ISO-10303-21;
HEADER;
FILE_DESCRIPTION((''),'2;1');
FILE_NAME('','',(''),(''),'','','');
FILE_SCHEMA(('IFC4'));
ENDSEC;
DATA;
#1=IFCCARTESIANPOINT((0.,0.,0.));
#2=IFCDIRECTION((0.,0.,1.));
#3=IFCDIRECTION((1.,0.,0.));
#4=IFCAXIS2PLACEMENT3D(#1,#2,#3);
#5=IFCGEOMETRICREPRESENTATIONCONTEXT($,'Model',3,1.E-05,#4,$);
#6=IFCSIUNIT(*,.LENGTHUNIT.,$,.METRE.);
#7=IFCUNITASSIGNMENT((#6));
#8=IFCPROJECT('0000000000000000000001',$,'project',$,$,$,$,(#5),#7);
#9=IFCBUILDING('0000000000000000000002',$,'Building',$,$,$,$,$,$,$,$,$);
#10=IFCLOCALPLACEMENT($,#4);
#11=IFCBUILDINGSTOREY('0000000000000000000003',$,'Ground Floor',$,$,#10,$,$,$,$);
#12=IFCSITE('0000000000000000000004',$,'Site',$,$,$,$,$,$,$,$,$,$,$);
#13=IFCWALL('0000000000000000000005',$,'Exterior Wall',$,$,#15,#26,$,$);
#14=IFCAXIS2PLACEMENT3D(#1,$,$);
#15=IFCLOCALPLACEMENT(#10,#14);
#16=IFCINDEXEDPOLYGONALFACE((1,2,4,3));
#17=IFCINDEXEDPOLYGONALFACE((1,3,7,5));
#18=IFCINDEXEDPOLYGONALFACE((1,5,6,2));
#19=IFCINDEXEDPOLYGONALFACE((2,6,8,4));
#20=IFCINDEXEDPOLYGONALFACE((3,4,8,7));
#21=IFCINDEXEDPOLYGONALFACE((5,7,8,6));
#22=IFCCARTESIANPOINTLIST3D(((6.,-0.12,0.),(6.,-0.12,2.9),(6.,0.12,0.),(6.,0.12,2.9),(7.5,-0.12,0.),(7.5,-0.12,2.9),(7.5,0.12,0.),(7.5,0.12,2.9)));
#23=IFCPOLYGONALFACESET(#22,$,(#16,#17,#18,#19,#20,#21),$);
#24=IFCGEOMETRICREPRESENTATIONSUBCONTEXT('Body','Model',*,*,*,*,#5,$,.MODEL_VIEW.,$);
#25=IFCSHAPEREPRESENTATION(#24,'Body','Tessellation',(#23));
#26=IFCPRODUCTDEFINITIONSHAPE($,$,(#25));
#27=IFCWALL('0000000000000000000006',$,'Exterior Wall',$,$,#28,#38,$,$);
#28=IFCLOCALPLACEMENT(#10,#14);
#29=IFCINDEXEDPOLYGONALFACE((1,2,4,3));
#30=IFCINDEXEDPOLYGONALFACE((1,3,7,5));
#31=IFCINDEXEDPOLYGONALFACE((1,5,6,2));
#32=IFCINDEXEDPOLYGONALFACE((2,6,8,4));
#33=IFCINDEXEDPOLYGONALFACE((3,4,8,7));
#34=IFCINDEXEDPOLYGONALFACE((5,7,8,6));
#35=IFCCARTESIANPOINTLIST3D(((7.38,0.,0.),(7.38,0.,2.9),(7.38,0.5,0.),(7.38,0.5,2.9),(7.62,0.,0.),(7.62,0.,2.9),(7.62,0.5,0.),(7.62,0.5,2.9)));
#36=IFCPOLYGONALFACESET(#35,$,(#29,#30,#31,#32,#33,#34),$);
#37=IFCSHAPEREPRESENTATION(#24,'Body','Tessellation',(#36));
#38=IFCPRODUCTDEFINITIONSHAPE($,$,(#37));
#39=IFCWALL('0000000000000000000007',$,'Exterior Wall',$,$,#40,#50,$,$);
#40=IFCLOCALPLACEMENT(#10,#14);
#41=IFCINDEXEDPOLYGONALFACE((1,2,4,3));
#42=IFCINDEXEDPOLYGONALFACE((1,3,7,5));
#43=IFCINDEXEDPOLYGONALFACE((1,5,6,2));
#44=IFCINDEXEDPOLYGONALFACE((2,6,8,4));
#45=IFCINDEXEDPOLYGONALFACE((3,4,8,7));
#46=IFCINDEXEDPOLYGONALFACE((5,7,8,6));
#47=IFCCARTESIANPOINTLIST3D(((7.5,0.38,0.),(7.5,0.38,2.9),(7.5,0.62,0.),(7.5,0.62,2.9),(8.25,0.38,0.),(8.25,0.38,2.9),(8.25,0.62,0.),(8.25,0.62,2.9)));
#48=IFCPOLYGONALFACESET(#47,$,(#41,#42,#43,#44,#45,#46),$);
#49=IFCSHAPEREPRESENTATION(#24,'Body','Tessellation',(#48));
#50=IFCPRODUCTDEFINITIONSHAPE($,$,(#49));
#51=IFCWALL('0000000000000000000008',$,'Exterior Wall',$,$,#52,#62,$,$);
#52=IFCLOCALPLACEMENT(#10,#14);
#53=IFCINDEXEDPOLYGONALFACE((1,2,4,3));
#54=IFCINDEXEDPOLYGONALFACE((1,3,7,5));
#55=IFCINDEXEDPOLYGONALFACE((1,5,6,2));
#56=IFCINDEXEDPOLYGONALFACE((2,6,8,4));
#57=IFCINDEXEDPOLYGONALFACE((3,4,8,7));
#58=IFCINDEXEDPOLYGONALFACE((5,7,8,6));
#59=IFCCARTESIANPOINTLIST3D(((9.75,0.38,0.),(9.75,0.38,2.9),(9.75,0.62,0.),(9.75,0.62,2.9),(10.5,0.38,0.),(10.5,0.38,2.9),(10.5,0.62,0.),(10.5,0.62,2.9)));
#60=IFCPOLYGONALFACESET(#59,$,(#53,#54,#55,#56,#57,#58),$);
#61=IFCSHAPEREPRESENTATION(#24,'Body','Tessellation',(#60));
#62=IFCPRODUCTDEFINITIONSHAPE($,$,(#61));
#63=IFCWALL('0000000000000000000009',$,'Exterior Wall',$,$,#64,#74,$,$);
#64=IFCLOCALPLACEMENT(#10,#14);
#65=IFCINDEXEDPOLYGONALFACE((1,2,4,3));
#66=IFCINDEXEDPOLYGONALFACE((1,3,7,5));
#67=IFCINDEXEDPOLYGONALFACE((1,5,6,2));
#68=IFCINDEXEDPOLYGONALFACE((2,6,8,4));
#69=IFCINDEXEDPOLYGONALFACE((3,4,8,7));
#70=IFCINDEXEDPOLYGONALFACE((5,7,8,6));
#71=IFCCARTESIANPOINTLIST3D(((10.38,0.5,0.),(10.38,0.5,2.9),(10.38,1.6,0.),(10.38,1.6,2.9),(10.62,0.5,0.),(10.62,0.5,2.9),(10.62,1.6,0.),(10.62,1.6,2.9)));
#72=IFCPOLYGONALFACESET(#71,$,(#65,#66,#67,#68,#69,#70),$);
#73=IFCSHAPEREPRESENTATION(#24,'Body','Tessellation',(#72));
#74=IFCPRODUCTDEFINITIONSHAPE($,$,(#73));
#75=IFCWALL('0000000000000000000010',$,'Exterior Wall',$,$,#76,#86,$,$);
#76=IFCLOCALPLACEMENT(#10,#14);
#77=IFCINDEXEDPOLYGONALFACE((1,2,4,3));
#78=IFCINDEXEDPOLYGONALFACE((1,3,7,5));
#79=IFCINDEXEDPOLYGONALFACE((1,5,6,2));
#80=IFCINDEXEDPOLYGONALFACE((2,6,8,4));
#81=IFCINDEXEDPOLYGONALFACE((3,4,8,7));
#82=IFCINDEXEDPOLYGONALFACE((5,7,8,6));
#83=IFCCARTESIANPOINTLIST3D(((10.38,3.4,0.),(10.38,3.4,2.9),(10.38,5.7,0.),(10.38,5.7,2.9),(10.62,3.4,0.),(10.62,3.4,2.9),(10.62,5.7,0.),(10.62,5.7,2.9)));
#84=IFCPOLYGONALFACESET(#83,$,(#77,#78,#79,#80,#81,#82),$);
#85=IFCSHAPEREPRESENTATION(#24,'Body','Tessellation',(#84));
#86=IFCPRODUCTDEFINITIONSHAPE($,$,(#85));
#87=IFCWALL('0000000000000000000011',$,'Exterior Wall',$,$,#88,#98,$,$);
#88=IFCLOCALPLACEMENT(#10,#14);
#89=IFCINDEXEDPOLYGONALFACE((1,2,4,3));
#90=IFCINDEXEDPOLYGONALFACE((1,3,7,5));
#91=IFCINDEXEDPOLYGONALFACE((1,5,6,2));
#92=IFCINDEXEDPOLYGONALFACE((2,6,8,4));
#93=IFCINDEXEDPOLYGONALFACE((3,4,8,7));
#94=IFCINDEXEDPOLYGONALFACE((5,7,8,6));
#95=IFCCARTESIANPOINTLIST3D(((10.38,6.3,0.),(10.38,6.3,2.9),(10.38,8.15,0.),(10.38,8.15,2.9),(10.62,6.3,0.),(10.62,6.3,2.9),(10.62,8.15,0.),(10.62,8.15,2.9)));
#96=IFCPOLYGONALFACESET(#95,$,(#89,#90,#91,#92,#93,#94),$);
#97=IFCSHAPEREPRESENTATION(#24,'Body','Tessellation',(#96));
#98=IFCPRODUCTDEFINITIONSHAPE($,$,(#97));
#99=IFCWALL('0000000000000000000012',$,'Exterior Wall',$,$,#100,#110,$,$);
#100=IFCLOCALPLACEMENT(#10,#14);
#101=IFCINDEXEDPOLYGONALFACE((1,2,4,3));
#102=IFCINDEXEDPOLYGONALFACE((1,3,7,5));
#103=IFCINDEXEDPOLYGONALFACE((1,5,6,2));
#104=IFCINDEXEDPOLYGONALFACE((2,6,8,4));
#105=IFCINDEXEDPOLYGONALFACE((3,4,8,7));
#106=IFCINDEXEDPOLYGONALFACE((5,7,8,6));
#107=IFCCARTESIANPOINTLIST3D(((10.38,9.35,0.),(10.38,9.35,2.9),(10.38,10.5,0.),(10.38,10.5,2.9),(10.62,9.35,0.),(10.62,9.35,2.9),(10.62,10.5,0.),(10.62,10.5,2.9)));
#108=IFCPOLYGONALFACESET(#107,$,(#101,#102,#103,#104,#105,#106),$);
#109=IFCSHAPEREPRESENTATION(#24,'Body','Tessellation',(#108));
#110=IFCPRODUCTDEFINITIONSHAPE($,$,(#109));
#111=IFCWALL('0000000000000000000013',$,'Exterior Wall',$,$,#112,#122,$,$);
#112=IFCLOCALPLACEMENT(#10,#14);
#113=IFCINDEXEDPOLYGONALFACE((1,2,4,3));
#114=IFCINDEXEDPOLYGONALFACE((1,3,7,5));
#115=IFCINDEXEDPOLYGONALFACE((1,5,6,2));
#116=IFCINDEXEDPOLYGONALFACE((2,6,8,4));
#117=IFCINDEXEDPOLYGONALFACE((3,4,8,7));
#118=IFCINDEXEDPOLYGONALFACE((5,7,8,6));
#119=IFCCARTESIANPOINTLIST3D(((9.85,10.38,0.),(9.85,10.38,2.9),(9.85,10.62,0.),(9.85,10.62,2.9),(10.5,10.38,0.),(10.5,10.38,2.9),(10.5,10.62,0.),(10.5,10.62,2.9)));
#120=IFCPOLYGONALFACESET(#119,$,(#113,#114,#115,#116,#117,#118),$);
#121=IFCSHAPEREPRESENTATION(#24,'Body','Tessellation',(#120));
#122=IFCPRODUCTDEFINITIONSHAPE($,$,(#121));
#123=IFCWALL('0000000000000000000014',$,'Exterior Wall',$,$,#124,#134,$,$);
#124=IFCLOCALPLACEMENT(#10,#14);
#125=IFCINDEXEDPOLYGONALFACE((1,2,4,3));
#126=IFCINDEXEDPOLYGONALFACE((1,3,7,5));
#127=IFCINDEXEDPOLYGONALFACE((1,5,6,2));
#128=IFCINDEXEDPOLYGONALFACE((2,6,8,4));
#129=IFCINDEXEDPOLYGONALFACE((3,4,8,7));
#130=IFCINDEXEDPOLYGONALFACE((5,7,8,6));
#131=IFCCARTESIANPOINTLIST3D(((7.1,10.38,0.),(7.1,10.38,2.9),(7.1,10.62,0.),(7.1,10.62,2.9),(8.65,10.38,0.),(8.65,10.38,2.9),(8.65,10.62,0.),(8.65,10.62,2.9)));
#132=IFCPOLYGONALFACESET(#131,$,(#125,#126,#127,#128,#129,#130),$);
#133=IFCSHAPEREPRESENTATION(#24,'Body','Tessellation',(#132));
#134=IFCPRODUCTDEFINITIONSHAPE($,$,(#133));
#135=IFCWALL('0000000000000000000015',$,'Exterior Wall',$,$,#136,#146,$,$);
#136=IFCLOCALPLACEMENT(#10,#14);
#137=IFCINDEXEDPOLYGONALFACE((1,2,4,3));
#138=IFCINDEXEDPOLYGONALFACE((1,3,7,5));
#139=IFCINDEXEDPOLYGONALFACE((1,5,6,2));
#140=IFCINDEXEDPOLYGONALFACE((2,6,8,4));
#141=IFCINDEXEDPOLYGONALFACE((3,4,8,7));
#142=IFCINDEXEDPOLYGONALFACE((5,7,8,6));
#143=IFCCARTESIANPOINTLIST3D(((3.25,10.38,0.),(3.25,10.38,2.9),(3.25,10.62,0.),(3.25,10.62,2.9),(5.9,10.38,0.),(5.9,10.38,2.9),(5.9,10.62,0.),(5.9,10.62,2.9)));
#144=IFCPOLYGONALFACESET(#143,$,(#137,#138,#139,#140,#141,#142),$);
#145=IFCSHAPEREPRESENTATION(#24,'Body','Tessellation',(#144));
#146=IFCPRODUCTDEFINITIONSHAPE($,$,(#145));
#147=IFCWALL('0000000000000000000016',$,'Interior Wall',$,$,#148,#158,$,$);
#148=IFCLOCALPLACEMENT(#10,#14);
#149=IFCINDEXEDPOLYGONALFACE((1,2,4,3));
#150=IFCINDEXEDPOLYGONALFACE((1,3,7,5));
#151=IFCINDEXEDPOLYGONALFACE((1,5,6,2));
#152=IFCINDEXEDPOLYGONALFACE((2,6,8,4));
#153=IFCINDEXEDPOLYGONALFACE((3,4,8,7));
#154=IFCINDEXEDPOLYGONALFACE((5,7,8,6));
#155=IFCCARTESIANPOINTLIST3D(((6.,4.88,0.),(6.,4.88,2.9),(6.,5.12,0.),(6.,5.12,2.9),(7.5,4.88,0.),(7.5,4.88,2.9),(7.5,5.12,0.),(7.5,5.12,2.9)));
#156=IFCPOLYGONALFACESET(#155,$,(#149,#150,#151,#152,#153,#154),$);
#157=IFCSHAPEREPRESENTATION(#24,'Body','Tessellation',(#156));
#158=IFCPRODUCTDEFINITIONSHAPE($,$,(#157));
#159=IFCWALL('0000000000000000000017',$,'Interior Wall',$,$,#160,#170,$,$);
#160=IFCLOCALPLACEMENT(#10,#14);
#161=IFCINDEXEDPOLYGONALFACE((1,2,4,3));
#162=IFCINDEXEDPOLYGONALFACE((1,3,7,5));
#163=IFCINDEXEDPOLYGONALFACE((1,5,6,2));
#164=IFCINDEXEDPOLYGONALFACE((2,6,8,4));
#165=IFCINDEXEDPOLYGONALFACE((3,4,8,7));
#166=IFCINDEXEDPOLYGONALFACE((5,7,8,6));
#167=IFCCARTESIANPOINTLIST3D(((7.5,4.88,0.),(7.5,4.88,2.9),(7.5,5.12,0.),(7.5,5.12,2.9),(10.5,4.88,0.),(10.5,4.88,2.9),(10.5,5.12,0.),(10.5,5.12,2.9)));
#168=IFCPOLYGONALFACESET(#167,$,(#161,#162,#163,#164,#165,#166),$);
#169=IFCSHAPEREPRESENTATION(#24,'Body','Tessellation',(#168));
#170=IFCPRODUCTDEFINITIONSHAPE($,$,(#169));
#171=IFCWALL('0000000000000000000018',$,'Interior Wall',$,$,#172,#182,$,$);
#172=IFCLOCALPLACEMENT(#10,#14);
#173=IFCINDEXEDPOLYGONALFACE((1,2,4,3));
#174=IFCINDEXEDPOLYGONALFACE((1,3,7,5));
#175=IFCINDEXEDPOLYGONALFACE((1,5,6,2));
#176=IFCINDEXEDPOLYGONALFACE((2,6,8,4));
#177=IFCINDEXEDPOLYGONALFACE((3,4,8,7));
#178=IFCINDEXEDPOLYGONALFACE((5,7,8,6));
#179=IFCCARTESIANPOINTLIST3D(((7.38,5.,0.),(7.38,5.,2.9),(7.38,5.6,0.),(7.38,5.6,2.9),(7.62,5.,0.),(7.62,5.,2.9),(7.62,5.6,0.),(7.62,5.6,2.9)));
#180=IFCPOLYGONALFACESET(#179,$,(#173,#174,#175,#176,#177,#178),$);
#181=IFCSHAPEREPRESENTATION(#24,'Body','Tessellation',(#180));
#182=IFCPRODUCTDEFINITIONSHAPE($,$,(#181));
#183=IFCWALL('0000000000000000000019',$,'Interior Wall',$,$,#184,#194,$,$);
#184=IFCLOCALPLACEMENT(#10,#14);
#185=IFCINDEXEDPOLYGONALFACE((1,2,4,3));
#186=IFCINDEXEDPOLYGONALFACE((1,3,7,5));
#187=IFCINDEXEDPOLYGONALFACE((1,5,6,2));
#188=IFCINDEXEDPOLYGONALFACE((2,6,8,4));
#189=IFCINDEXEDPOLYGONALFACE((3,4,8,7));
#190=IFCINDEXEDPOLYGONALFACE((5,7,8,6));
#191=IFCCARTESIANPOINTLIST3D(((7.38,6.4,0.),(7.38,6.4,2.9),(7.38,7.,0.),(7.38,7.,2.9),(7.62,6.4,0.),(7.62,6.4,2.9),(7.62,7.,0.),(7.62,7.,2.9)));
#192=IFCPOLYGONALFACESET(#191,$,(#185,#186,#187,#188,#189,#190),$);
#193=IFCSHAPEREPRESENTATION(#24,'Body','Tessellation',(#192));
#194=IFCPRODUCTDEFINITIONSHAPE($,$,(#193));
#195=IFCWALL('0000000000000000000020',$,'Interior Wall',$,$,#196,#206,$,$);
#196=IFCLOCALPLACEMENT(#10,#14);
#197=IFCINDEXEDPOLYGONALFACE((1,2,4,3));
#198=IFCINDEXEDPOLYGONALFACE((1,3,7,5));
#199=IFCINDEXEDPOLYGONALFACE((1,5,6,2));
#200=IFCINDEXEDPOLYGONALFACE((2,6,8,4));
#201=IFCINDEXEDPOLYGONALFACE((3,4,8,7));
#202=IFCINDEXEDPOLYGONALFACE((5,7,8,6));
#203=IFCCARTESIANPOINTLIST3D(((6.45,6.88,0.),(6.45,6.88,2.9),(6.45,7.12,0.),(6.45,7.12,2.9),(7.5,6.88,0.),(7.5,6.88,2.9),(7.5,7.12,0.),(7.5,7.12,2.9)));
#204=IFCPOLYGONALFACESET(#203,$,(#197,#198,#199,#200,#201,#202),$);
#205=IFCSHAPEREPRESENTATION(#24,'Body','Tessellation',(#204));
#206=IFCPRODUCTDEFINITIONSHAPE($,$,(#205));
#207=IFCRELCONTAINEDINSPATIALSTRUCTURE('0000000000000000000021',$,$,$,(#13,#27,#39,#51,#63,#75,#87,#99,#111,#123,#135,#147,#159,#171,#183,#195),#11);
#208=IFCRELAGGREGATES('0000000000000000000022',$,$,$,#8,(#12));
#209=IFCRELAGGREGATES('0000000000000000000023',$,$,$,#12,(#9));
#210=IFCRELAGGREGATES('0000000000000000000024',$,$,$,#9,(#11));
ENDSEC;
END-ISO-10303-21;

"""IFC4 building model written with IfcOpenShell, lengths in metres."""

from ifc_helpers import new_model, si_unit, frame, origin_with_axes, place, context, subcontext, project, spatial, indexed_curve, outline, extrude, element, save


model = new_model("IFC4")

# Units and contexts
model_context = context("Model", 3, precision=1e-05, world=origin_with_axes())
body_context = subcontext(model_context, "Body", "Model", "MODEL_VIEW")
ifc_project = project(units=[si_unit("LENGTHUNIT", "METRE")], contexts=[model_context])

# Site, building, storey
site = spatial("IfcSite", under=ifc_project, Name="Site")
building = spatial("IfcBuilding", under=site, Name="Building")
storey_placement = place(None, origin_with_axes())
storey = spatial("IfcBuildingStorey", under=building, at=storey_placement, Name="Ground Floor")

# Walls
wall_1_placement = place(storey_placement, frame((6.0, 0.0, 0.0), z_axis=(0.0, 0.0, 1.0), x_axis=(1.0, 0.0, 0.0)))
element("IfcWall", 1, at=wall_1_placement, inside=storey, Name="Exterior Wall", context=body_context, shape_type="SweptSolid", body=[
    extrude(outline(indexed_curve([(0.0, 0.0), (0.0, 0.24), (1.5, 0.24), (1.5, 0.0), (0.0, 0.0)], self_intersect=False)), frame((0.0, -0.12, 0.0), z_axis=(0.0, 0.0, 1.0), x_axis=(1.0, 0.0, 0.0)), (0.0, 0.0, 1.0), 2.9),
])
wall_2_placement = place(storey_placement, frame((7.5, 0.0, 0.0), z_axis=(0.0, 0.0, 1.0), x_axis=(0.0, 1.0, 0.0)))
element("IfcWall", 2, at=wall_2_placement, inside=storey, Name="Exterior Wall", context=body_context, shape_type="SweptSolid", body=[
    extrude(outline(indexed_curve([(0.0, 0.0), (0.0, 0.24), (0.5, 0.24), (0.5, 0.0), (0.0, 0.0)], self_intersect=False)), frame((0.0, -0.12, 0.0), z_axis=(0.0, 0.0, 1.0), x_axis=(1.0, 0.0, 0.0)), (0.0, 0.0, 1.0), 2.9),
])
for number, where, z_axis, x_axis, name in (
    (3, (7.5, 0.5, 0.0), (0.0, 0.0, 1.0), (1.0, 0.0, 0.0), "Exterior Wall"),
    (4, (9.75, 0.5, 0.0), (0.0, 0.0, 1.0), (1.0, 0.0, 0.0), "Exterior Wall"),
):
    element("IfcWall", number, at=place(storey_placement, frame(where, z_axis=z_axis, x_axis=x_axis)), inside=storey, Name=name, context=body_context, shape_type="SweptSolid", body=[
        extrude(outline(indexed_curve([(0.0, 0.0), (0.0, 0.24), (0.75, 0.24), (0.75, 0.0), (0.0, 0.0)], self_intersect=False)), frame((0.0, -0.12, 0.0), z_axis=(0.0, 0.0, 1.0), x_axis=(1.0, 0.0, 0.0)), (0.0, 0.0, 1.0), 2.9),
    ])
wall_3_placement = place(storey_placement, frame((10.5, 0.5, 0.0), z_axis=(0.0, 0.0, 1.0), x_axis=(0.0, 1.0, 0.0)))
element("IfcWall", 5, at=wall_3_placement, inside=storey, Name="Exterior Wall", context=body_context, shape_type="SweptSolid", body=[
    extrude(outline(indexed_curve([(0.0, 0.0), (0.0, 0.24), (1.1, 0.24), (1.1, 0.0), (0.0, 0.0)], self_intersect=False)), frame((0.0, -0.12, 0.0), z_axis=(0.0, 0.0, 1.0), x_axis=(1.0, 0.0, 0.0)), (0.0, 0.0, 1.0), 2.9),
])
wall_4_placement = place(storey_placement, frame((10.5, 3.4, 0.0), z_axis=(0.0, 0.0, 1.0), x_axis=(0.0, 1.0, 0.0)))
element("IfcWall", 6, at=wall_4_placement, inside=storey, Name="Exterior Wall", context=body_context, shape_type="SweptSolid", body=[
    extrude(outline(indexed_curve([(0.0, 0.0), (0.0, 0.24), (2.3, 0.24), (2.3, 0.0), (0.0, 0.0)], self_intersect=False)), frame((0.0, -0.12, 0.0), z_axis=(0.0, 0.0, 1.0), x_axis=(1.0, 0.0, 0.0)), (0.0, 0.0, 1.0), 2.9),
])
wall_5_placement = place(storey_placement, frame((10.5, 6.3, 0.0), z_axis=(0.0, 0.0, 1.0), x_axis=(0.0, 1.0, 0.0)))
element("IfcWall", 7, at=wall_5_placement, inside=storey, Name="Exterior Wall", context=body_context, shape_type="SweptSolid", body=[
    extrude(outline(indexed_curve([(0.0, 0.0), (0.0, 0.24), (1.85, 0.24), (1.85, 0.0), (0.0, 0.0)], self_intersect=False)), frame((0.0, -0.12, 0.0), z_axis=(0.0, 0.0, 1.0), x_axis=(1.0, 0.0, 0.0)), (0.0, 0.0, 1.0), 2.9),
])
wall_6_placement = place(storey_placement, frame((10.5, 9.35, 0.0), z_axis=(0.0, 0.0, 1.0), x_axis=(0.0, 1.0, 0.0)))
element("IfcWall", 8, at=wall_6_placement, inside=storey, Name="Exterior Wall", context=body_context, shape_type="SweptSolid", body=[
    extrude(outline(indexed_curve([(0.0, 0.0), (0.0, 0.24), (1.15, 0.24), (1.15, 0.0), (0.0, 0.0)], self_intersect=False)), frame((0.0, -0.12, 0.0), z_axis=(0.0, 0.0, 1.0), x_axis=(1.0, 0.0, 0.0)), (0.0, 0.0, 1.0), 2.9),
])
wall_7_placement = place(storey_placement, frame((10.5, 10.5, 0.0), z_axis=(0.0, 0.0, 1.0), x_axis=(-1.0, 0.0, 0.0)))
element("IfcWall", 9, at=wall_7_placement, inside=storey, Name="Exterior Wall", context=body_context, shape_type="SweptSolid", body=[
    extrude(outline(indexed_curve([(0.0, 0.0), (0.0, 0.24), (0.65, 0.24), (0.65, 0.0), (0.0, 0.0)], self_intersect=False)), frame((0.0, -0.12, 0.0), z_axis=(0.0, 0.0, 1.0), x_axis=(1.0, 0.0, 0.0)), (0.0, 0.0, 1.0), 2.9),
])
wall_8_placement = place(storey_placement, frame((8.65, 10.5, 0.0), z_axis=(0.0, 0.0, 1.0), x_axis=(-1.0, 0.0, 0.0)))
element("IfcWall", 10, at=wall_8_placement, inside=storey, Name="Exterior Wall", context=body_context, shape_type="SweptSolid", body=[
    extrude(outline(indexed_curve([(0.0, 0.0), (0.0, 0.24), (1.55, 0.24), (1.55, 0.0), (0.0, 0.0)], self_intersect=False)), frame((0.0, -0.12, 0.0), z_axis=(0.0, 0.0, 1.0), x_axis=(1.0, 0.0, 0.0)), (0.0, 0.0, 1.0), 2.9),
])
wall_9_placement = place(storey_placement, frame((5.9, 10.5, 0.0), z_axis=(0.0, 0.0, 1.0), x_axis=(-1.0, 0.0, 0.0)))
element("IfcWall", 11, at=wall_9_placement, inside=storey, Name="Exterior Wall", context=body_context, shape_type="SweptSolid", body=[
    extrude(outline(indexed_curve([(0.0, 0.0), (0.0, 0.24), (2.65, 0.24), (2.65, 0.0), (0.0, 0.0)], self_intersect=False)), frame((0.0, -0.12, 0.0), z_axis=(0.0, 0.0, 1.0), x_axis=(1.0, 0.0, 0.0)), (0.0, 0.0, 1.0), 2.9),
])
wall_10_placement = place(storey_placement, frame((7.5, 5.0, 0.0), z_axis=(0.0, 0.0, 1.0), x_axis=(-1.0, 0.0, 0.0)))
element("IfcWall", 12, at=wall_10_placement, inside=storey, Name="Interior Wall", context=body_context, shape_type="SweptSolid", body=[
    extrude(outline(indexed_curve([(0.0, 0.0), (0.0, 0.24), (1.5, 0.24), (1.5, 0.0), (0.0, 0.0)], self_intersect=False)), frame((0.0, -0.12, 0.0), z_axis=(0.0, 0.0, 1.0), x_axis=(1.0, 0.0, 0.0)), (0.0, 0.0, 1.0), 2.9),
])
wall_11_placement = place(storey_placement, frame((10.5, 5.0, 0.0), z_axis=(0.0, 0.0, 1.0), x_axis=(-1.0, 0.0, 0.0)))
element("IfcWall", 13, at=wall_11_placement, inside=storey, Name="Interior Wall", context=body_context, shape_type="SweptSolid", body=[
    extrude(outline(indexed_curve([(0.0, 0.0), (0.0, 0.24), (3.0, 0.24), (3.0, 0.0), (0.0, 0.0)], self_intersect=False)), frame((0.0, -0.12, 0.0), z_axis=(0.0, 0.0, 1.0), x_axis=(1.0, 0.0, 0.0)), (0.0, 0.0, 1.0), 2.9),
])
for number, where, z_axis, x_axis, name in (
    (14, (7.5, 5.0, 0.0), (0.0, 0.0, 1.0), (0.0, 1.0, 0.0), "Interior Wall"),
    (15, (7.5, 6.4, 0.0), (0.0, 0.0, 1.0), (0.0, 1.0, 0.0), "Interior Wall"),
):
    element("IfcWall", number, at=place(storey_placement, frame(where, z_axis=z_axis, x_axis=x_axis)), inside=storey, Name=name, context=body_context, shape_type="SweptSolid", body=[
        extrude(outline(indexed_curve([(0.0, 0.0), (0.0, 0.24), (0.6, 0.24), (0.6, 0.0), (0.0, 0.0)], self_intersect=False)), frame((0.0, -0.12, 0.0), z_axis=(0.0, 0.0, 1.0), x_axis=(1.0, 0.0, 0.0)), (0.0, 0.0, 1.0), 2.9),
    ])
wall_12_placement = place(storey_placement, frame((7.5, 7.0, 0.0), z_axis=(0.0, 0.0, 1.0), x_axis=(-1.0, 0.0, 0.0)))
element("IfcWall", 16, at=wall_12_placement, inside=storey, Name="Interior Wall", context=body_context, shape_type="SweptSolid", body=[
    extrude(outline(indexed_curve([(0.0, 0.0), (0.0, 0.24), (1.05, 0.24), (1.05, 0.0), (0.0, 0.0)], self_intersect=False)), frame((0.0, -0.12, 0.0), z_axis=(0.0, 0.0, 1.0), x_axis=(1.0, 0.0, 0.0)), (0.0, 0.0, 1.0), 2.9),
])

save(model, "model.ifc")
